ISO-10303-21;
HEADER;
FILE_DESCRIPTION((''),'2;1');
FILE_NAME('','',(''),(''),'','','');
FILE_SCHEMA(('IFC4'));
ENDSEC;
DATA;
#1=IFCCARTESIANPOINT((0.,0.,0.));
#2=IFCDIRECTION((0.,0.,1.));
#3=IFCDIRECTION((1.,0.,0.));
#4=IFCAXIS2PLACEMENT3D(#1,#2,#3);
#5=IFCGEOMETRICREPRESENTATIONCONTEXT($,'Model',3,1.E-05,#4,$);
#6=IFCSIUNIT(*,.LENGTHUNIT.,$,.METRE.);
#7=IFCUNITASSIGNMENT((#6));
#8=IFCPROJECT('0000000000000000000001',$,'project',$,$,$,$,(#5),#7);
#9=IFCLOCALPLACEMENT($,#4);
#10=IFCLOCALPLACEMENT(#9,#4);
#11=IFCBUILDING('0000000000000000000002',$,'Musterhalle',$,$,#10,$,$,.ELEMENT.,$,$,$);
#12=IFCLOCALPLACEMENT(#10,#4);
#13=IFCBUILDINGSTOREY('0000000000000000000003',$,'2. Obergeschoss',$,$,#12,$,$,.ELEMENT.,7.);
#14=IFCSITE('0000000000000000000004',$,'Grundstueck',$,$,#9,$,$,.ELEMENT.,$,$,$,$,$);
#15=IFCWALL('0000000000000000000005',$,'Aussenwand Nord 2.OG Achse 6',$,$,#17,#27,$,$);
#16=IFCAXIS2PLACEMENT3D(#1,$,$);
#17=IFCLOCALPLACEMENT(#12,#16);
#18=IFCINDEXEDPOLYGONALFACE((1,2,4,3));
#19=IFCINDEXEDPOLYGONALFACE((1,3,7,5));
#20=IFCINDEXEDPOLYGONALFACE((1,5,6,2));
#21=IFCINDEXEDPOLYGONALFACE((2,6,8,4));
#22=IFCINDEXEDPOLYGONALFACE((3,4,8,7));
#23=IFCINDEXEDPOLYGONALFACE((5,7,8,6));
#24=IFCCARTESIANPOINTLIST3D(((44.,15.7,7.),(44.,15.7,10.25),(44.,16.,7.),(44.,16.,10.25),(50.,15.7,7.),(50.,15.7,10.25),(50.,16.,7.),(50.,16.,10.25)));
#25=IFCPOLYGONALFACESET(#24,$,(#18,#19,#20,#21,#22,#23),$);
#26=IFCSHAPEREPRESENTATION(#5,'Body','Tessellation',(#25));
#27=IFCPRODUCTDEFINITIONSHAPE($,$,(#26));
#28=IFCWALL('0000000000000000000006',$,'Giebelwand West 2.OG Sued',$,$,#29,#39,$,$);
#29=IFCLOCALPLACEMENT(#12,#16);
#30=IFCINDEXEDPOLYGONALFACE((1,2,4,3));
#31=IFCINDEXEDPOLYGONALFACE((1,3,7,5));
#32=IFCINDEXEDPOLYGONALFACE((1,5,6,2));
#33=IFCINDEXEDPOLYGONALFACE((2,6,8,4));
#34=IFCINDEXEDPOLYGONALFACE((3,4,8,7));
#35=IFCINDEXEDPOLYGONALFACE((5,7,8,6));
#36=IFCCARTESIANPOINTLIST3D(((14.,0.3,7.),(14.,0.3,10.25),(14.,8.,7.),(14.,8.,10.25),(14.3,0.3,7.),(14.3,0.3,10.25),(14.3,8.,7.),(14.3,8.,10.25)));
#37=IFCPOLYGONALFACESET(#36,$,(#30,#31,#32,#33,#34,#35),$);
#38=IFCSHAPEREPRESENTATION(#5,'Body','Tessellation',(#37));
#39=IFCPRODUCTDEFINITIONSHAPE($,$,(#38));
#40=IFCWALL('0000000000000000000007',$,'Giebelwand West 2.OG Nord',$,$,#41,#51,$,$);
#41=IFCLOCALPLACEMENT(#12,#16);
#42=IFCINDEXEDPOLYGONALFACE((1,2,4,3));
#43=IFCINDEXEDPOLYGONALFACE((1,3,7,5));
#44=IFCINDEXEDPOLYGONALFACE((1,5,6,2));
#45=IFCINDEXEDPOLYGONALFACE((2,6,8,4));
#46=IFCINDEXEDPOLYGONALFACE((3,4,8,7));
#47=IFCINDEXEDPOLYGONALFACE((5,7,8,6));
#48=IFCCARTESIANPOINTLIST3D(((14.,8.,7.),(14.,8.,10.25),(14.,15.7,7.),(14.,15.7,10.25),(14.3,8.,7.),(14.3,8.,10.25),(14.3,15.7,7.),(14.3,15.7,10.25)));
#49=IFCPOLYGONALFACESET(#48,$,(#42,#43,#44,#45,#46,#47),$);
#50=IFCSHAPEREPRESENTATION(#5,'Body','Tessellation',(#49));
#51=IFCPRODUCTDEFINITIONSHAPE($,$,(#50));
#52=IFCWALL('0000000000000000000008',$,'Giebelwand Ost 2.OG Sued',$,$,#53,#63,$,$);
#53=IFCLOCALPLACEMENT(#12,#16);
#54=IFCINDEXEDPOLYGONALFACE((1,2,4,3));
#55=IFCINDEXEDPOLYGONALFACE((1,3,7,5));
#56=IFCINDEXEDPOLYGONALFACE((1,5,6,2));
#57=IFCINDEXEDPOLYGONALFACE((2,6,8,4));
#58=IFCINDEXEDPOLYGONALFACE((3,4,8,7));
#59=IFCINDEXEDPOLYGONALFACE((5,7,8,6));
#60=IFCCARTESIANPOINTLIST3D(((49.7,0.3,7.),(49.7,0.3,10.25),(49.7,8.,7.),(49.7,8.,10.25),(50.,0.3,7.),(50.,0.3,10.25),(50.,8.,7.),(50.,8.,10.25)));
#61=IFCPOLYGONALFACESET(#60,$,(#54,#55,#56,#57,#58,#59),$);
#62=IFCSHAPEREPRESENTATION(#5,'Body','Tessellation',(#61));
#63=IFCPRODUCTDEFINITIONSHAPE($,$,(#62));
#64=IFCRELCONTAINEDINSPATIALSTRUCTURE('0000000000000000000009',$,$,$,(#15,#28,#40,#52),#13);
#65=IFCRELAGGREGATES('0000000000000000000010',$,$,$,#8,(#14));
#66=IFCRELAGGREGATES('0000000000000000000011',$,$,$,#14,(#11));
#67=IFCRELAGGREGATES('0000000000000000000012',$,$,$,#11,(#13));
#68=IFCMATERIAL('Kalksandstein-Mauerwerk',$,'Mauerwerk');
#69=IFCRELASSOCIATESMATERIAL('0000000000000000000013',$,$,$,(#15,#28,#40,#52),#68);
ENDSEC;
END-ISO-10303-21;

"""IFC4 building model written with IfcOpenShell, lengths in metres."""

from ifc_helpers import new_model, si_unit, frame, origin_with_axes, origin_2d, place, context, project, spatial, rectangle, extrude, material, element, save


model = new_model("IFC4")

# Units and contexts
model_context = context("Model", 3, precision=1e-05, world=origin_with_axes())
ifc_project = project(units=[si_unit("LENGTHUNIT", "METRE")], contexts=[model_context])

# Site, building, storey
site_placement = place(None, origin_with_axes())
site = spatial("IfcSite", under=ifc_project, at=site_placement, Name="Grundstueck", CompositionType="ELEMENT")
building_placement = place(site_placement, origin_with_axes())
building = spatial("IfcBuilding", under=site, at=building_placement, Name="Musterhalle", CompositionType="ELEMENT")
storey_placement = place(building_placement, origin_with_axes())
storey = spatial("IfcBuildingStorey", under=building, at=storey_placement, Name="2. Obergeschoss", CompositionType="ELEMENT", Elevation=7.0)

# Shared definitions
placement = place(storey_placement, origin_with_axes())

# Walls
ifc_material_1 = material(Name="Kalksandstein-Mauerwerk", Category="Mauerwerk")
element("IfcWall", 1, at=placement, inside=storey, material=ifc_material_1, Name="Aussenwand Nord 2.OG Achse 6", context=model_context, shape_type="SweptSolid", body=[
    extrude(rectangle(XDim=6.0, YDim=0.3, at=origin_2d()), frame((47.0, 15.85, 7.0), z_axis=(0.0, 0.0, 1.0), x_axis=(1.0, 0.0, 0.0)), (0.0, 0.0, 1.0), 3.25),
])
element("IfcWall", 2, at=placement, inside=storey, material=ifc_material_1, Name="Giebelwand West 2.OG Sued", context=model_context, shape_type="SweptSolid", body=[
    extrude(rectangle(XDim=0.3, YDim=7.7, at=origin_2d()), frame((14.15, 4.15, 7.0), z_axis=(0.0, 0.0, 1.0), x_axis=(1.0, 0.0, 0.0)), (0.0, 0.0, 1.0), 3.25),
])
element("IfcWall", 3, at=placement, inside=storey, material=ifc_material_1, Name="Giebelwand West 2.OG Nord", context=model_context, shape_type="SweptSolid", body=[
    extrude(rectangle(XDim=0.3, YDim=7.7, at=origin_2d()), frame((14.15, 11.85, 7.0), z_axis=(0.0, 0.0, 1.0), x_axis=(1.0, 0.0, 0.0)), (0.0, 0.0, 1.0), 3.25),
])
element("IfcWall", 4, at=placement, inside=storey, material=ifc_material_1, Name="Giebelwand Ost 2.OG Sued", context=model_context, shape_type="SweptSolid", body=[
    extrude(rectangle(XDim=0.3, YDim=7.7, at=origin_2d()), frame((49.85, 4.15, 7.0), z_axis=(0.0, 0.0, 1.0), x_axis=(1.0, 0.0, 0.0)), (0.0, 0.0, 1.0), 3.25),
])

save(model, "model.ifc")
